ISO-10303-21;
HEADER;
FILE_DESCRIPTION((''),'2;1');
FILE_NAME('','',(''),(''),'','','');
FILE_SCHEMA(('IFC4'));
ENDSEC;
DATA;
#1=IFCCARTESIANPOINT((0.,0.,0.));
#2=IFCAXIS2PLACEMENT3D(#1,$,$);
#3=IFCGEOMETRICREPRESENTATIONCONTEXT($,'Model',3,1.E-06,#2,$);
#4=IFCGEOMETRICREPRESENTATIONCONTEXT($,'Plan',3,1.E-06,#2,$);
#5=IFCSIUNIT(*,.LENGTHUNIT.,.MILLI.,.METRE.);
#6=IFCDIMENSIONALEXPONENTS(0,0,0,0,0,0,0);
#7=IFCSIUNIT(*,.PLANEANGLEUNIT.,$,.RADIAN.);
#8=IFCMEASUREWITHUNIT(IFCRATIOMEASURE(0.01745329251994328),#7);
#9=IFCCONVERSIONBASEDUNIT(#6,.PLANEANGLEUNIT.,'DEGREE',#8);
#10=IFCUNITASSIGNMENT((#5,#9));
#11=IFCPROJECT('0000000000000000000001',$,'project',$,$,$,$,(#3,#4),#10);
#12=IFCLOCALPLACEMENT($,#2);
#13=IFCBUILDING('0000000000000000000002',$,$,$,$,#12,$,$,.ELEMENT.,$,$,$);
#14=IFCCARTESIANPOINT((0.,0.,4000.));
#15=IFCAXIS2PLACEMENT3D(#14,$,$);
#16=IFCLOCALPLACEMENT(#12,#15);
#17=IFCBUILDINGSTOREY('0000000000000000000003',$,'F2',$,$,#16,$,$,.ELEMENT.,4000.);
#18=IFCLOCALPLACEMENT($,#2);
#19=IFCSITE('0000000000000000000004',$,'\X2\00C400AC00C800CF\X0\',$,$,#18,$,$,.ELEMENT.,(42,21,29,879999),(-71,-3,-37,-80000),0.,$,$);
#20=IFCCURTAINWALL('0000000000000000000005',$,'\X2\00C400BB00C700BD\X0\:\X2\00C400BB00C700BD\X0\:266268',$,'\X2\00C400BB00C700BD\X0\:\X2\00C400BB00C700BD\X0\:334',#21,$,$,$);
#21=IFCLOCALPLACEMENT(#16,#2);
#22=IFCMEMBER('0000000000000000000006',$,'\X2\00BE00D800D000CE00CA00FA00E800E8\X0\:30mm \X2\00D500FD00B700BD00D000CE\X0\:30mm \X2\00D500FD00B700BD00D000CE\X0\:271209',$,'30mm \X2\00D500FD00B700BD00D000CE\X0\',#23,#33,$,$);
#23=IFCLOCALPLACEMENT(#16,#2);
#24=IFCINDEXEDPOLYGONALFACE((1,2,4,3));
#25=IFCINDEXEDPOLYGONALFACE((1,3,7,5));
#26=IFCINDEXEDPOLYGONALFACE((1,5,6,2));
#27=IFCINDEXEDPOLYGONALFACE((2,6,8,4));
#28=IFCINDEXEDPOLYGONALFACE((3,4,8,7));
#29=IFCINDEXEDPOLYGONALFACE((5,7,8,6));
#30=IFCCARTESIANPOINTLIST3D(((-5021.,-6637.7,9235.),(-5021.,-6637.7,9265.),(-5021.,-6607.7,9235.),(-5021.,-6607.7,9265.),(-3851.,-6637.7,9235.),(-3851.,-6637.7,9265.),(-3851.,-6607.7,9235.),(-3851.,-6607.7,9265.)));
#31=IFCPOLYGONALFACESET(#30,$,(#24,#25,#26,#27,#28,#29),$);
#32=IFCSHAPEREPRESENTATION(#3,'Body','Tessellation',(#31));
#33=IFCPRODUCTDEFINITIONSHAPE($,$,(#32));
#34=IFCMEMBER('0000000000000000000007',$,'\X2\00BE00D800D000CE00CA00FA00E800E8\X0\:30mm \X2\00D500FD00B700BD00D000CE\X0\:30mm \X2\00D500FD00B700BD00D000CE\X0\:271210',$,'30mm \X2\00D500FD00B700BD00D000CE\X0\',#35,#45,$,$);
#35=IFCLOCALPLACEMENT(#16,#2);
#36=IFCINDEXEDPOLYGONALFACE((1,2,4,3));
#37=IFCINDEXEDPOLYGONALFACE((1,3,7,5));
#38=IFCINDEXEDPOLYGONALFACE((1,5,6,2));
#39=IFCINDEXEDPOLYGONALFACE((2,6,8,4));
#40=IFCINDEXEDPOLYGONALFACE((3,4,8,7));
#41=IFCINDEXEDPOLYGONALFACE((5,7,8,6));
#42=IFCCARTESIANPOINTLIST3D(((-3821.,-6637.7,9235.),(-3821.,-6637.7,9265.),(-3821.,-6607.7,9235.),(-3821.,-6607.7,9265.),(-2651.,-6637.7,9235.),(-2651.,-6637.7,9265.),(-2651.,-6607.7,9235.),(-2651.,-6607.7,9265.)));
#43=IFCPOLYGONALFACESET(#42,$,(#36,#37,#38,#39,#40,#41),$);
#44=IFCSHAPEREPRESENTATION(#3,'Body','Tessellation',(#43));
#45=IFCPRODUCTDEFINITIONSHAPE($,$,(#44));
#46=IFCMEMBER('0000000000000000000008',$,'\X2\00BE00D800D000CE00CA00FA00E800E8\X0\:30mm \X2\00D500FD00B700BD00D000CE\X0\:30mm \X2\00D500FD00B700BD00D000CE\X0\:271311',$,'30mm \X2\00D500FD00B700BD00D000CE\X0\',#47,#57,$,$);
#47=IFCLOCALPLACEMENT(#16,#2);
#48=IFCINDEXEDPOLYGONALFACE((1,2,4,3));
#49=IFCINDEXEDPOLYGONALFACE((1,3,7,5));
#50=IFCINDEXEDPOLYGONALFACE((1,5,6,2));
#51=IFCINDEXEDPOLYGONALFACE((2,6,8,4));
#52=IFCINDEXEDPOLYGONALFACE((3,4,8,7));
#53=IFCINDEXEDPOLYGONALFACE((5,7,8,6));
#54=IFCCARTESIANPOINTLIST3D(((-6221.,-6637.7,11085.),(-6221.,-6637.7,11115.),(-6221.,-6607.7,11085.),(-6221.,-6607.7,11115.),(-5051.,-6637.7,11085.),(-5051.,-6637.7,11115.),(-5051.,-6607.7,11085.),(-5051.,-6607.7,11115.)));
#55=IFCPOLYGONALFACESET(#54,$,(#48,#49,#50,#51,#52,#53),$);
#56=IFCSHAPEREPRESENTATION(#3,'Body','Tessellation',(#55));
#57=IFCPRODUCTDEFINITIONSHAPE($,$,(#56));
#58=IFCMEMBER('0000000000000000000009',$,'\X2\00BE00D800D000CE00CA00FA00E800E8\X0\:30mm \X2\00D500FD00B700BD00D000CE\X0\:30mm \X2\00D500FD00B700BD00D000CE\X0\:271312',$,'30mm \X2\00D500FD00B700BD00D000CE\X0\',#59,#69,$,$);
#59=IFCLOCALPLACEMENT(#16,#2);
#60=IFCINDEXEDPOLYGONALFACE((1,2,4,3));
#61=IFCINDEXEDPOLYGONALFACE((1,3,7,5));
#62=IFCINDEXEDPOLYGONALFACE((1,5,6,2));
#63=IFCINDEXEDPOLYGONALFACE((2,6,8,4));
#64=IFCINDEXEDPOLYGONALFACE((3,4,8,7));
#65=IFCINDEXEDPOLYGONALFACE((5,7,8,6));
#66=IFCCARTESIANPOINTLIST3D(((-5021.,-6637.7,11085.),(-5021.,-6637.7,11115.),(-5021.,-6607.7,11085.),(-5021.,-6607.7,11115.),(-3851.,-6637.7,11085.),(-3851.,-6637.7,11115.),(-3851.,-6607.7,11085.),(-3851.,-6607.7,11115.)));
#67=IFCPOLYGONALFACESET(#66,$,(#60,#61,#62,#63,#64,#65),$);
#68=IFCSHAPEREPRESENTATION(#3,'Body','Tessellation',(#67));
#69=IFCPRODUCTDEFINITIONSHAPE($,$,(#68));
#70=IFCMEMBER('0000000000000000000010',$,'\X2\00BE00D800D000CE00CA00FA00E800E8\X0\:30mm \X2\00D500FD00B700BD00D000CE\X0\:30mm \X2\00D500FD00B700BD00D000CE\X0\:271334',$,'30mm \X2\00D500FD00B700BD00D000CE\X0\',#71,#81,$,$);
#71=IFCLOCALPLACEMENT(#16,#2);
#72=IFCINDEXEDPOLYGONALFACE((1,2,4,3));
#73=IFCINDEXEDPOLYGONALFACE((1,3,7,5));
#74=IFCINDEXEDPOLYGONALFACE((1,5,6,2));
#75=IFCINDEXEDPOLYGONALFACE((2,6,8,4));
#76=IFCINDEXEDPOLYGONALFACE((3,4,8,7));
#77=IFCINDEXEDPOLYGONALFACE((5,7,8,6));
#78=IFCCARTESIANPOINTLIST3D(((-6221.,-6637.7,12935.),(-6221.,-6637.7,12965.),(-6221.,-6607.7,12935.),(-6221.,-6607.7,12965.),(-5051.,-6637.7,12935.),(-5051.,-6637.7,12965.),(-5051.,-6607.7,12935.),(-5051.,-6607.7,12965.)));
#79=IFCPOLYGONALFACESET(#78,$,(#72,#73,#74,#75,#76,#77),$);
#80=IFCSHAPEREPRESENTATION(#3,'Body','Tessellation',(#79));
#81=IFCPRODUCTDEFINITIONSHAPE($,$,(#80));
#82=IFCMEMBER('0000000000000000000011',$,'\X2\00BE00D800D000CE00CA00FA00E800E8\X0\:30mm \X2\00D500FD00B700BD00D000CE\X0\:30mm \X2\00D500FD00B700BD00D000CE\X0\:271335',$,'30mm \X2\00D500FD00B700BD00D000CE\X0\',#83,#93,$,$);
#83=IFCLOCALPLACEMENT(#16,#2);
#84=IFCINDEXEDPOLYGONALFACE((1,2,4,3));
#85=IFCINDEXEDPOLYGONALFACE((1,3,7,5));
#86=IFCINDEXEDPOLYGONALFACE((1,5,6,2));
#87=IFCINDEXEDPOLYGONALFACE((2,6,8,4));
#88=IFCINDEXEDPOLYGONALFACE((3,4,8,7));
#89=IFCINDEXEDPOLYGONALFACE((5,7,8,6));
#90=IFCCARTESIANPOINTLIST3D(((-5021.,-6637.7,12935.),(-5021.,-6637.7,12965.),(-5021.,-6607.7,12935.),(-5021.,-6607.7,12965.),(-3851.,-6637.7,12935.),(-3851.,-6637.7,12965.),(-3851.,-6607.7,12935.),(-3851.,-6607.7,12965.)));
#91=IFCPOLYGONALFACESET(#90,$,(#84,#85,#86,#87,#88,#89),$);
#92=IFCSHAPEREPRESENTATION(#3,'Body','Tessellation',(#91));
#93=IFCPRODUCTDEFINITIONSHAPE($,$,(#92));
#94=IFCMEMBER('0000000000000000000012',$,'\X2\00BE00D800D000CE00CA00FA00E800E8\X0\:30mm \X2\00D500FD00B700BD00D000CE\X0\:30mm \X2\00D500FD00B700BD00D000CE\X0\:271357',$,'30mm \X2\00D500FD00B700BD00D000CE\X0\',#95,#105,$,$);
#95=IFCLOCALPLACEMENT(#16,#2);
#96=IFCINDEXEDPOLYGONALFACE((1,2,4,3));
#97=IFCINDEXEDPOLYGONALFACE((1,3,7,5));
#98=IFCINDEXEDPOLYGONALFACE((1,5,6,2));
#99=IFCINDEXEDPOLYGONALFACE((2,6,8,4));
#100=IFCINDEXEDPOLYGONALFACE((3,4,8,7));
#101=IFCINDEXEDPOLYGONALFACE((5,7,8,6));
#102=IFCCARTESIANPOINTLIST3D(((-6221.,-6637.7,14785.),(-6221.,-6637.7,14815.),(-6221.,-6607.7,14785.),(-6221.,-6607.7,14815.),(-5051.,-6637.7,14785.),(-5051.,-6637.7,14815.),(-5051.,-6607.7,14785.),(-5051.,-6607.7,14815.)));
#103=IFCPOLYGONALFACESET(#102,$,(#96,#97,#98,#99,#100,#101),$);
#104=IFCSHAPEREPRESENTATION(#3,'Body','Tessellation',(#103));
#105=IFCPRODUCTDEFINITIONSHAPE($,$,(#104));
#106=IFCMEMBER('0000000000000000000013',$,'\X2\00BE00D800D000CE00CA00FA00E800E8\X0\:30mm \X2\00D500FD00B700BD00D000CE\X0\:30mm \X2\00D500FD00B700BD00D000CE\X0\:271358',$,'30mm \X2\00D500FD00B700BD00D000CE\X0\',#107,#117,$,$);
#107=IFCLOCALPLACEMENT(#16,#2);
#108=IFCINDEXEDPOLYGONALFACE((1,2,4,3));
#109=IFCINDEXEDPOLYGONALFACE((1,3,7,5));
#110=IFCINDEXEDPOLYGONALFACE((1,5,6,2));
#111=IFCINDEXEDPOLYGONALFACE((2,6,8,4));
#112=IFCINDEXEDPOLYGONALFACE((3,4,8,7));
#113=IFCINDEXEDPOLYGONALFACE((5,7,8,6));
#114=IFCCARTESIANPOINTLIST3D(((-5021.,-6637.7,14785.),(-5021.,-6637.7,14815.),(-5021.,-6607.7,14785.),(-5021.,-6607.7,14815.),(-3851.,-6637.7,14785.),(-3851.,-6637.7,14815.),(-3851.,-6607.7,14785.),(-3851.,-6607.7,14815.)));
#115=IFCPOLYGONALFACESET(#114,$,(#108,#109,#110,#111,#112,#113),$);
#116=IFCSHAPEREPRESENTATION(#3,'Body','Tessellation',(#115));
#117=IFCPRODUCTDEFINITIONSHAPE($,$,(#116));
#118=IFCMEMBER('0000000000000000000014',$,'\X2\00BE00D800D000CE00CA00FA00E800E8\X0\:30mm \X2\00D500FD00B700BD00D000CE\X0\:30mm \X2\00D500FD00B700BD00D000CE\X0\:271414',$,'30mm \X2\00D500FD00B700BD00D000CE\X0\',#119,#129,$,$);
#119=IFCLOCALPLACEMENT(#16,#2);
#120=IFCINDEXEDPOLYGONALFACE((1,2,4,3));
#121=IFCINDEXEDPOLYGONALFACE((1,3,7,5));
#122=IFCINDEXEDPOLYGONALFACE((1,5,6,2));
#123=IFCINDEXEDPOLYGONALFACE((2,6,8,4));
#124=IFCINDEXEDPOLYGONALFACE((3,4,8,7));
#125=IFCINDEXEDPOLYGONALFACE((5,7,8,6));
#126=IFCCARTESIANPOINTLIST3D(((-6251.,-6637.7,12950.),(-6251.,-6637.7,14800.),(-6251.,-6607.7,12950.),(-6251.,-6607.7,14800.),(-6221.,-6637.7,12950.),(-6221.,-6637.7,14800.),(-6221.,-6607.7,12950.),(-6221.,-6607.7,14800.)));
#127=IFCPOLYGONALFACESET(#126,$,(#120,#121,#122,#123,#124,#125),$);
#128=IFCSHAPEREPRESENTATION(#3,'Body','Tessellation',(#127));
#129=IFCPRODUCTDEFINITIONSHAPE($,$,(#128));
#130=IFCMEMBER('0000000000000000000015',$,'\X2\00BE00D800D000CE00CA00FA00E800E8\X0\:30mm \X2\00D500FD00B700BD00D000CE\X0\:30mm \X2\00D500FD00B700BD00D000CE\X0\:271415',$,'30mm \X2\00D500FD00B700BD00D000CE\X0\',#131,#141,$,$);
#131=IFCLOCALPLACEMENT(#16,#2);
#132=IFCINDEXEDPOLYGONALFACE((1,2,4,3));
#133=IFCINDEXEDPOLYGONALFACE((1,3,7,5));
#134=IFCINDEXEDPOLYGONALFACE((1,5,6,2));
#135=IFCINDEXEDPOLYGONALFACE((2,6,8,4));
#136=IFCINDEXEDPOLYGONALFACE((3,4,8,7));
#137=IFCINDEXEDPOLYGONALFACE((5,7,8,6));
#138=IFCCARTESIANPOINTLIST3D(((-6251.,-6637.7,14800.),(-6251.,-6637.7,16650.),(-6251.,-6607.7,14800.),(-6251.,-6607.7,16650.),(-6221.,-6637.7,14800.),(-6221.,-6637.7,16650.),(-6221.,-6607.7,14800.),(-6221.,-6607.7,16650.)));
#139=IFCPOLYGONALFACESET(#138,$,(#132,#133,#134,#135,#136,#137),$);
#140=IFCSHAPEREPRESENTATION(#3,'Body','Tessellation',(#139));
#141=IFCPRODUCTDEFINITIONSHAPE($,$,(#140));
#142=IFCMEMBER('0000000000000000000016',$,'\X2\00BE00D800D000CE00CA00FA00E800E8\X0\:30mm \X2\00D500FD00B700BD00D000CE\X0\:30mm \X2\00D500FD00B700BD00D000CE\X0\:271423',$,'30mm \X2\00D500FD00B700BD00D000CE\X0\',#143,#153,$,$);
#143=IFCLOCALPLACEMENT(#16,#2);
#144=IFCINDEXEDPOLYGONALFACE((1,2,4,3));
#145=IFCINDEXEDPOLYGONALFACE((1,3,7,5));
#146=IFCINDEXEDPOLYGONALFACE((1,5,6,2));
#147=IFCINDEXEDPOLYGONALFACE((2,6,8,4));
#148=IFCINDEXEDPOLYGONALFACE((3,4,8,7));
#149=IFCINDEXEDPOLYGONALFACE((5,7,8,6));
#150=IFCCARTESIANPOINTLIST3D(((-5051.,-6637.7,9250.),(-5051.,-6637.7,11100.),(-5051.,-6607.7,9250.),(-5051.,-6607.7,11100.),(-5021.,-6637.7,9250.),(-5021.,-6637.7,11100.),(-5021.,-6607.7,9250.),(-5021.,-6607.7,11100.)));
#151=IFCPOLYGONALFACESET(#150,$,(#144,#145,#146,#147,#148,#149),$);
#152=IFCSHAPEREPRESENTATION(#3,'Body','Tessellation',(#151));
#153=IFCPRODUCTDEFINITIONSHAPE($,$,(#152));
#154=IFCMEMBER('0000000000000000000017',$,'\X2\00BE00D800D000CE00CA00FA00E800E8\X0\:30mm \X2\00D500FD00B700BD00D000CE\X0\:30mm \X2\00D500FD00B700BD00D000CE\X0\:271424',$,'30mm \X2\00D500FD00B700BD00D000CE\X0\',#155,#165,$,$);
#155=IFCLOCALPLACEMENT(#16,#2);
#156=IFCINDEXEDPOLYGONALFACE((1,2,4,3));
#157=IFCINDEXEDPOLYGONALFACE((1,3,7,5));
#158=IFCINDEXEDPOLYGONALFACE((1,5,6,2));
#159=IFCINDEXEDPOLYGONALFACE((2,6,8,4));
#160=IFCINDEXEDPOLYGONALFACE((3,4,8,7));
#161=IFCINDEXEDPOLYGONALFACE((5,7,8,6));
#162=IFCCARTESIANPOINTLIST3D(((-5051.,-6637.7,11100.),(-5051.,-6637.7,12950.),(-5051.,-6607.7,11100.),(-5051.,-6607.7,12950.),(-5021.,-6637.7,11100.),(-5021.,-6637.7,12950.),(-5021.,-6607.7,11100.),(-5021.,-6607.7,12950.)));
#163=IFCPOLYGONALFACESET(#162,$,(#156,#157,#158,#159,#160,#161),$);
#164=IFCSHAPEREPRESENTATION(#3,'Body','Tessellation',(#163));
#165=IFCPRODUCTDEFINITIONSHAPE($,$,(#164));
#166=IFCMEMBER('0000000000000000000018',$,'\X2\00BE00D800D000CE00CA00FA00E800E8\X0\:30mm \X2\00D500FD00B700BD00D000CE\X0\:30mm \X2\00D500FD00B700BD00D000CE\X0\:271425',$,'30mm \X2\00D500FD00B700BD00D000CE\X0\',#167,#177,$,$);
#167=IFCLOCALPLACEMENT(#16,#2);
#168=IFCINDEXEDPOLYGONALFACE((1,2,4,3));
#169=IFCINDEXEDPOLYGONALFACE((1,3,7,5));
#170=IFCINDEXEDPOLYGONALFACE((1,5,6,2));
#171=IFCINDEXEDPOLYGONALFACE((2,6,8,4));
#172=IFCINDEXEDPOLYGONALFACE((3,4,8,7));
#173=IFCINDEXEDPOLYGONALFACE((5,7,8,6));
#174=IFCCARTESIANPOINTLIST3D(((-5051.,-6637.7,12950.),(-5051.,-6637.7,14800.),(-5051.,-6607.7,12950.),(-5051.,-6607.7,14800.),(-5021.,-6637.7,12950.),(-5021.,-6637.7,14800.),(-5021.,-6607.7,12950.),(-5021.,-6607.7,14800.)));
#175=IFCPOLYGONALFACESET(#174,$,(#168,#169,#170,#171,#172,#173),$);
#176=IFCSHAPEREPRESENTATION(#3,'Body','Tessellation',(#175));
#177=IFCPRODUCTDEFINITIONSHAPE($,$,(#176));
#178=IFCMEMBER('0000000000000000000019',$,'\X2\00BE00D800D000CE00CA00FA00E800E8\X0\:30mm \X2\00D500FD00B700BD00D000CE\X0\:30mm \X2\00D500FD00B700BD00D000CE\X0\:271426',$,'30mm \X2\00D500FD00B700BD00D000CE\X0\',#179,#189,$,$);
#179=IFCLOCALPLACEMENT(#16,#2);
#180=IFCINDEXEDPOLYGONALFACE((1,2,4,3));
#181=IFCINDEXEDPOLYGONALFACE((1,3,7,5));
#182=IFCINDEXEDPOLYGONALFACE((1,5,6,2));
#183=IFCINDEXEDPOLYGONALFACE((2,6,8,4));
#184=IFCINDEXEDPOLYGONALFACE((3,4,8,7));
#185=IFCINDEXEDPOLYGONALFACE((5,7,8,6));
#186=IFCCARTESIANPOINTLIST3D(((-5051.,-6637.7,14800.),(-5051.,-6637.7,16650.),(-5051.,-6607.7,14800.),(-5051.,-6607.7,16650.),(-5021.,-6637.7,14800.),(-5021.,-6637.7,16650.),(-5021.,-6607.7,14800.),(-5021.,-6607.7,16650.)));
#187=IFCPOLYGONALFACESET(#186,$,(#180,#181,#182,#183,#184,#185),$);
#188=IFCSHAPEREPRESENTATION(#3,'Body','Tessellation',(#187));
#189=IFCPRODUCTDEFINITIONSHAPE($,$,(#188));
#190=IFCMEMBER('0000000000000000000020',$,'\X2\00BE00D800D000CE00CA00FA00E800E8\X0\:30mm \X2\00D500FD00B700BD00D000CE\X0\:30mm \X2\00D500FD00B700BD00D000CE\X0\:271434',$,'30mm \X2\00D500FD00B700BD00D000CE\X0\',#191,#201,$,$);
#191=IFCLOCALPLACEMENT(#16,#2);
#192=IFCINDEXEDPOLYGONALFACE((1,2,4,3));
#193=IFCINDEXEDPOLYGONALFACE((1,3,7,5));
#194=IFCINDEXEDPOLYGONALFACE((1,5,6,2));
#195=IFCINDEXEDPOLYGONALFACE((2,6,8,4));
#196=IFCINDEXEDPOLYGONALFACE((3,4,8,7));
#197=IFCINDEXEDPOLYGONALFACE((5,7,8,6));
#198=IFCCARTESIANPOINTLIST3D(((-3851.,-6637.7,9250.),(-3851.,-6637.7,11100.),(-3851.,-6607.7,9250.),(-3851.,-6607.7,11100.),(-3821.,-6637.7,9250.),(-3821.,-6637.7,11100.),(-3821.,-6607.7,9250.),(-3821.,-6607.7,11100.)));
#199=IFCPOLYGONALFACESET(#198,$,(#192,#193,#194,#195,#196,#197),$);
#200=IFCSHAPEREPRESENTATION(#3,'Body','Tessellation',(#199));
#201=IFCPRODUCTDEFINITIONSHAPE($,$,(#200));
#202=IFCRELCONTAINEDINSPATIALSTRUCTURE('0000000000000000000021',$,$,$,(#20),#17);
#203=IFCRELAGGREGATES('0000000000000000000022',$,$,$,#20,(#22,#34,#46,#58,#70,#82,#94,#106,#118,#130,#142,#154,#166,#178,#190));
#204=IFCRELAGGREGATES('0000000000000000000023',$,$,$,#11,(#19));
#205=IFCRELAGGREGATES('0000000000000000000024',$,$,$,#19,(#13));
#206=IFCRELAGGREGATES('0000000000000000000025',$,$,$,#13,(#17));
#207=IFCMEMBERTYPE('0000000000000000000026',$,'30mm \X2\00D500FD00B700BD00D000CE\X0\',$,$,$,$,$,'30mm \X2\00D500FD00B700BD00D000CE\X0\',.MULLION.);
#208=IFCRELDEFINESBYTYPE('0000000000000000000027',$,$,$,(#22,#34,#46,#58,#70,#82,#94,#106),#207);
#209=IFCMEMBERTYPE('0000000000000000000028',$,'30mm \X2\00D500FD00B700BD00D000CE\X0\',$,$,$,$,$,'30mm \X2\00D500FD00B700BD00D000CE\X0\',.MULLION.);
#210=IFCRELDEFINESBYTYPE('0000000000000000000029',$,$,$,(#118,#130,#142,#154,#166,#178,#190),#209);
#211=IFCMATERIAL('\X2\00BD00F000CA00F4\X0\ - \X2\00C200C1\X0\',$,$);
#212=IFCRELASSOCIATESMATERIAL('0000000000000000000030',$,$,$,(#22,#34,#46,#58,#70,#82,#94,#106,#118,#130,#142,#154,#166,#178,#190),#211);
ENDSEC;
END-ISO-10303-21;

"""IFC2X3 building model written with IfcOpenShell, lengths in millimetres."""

from ifc_helpers import new_model, entity, si_unit, converted_unit, frame, origin, origin_2d_with_axis, place, context, project, spatial, rectangle, extrude, source, transform, mapped, material, type_object, type_shapes, element, aggregate, save


model = new_model("IFC2X3")

# Units and contexts
model_context = context("Model", 3, precision=1e-06, world=origin())
plan_context = context("Plan", 3, precision=1e-06, world=origin())
ifc_project = project(units=[si_unit("LENGTHUNIT", "METRE", prefix="MILLI"), converted_unit("PLANEANGLEUNIT", "DEGREE", entity("IfcRatioMeasure", 0.01745329251994328), si_unit("PLANEANGLEUNIT", "RADIAN"), dimensions=[0, 0, 0, 0, 0, 0, 0])], contexts=[model_context, plan_context])

# Site, building, storey
site_placement = place(None, origin())
site = spatial("IfcSite", under=ifc_project, at=site_placement, Name="Ä¬ÈÏ", CompositionType="ELEMENT", RefLatitude=(42, 21, 29, 879999), RefLongitude=(-71, -3, -37, -80000), RefElevation=0.0)
building_placement = place(None, origin())
building = spatial("IfcBuilding", under=site, at=building_placement, CompositionType="ELEMENT")
storey_placement = place(building_placement, frame((0.0, 0.0, 4000.0)))
storey = spatial("IfcBuildingStorey", under=building, at=storey_placement, Name="F2", CompositionType="ELEMENT", Elevation=4000.0)

# Curtain wall, members
curtain_wall_placement = place(storey_placement, origin())
curtain_wall = element("IfcCurtainWall", 1, at=curtain_wall_placement, inside=storey, Name="Ä»Ç½:Ä»Ç½:266268", ObjectType="Ä»Ç½:Ä»Ç½:334")
ifc_material_1 = material(Name="½ðÊô - ÂÁ")
member_type_1 = type_object("IfcMemberType", Name="30mm Õý·½ÐÎ", ElementType="30mm Õý·½ÐÎ", PredefinedType="MULLION")
shared_shape_1 = source(origin(), model_context, "Body", "SweptSolid", [
    extrude(rectangle(XDim=30.0, YDim=30.0, at=origin_2d_with_axis()), frame((0.0, 0.0, -1170.0), z_axis=(0.0, 0.0, 1.0), x_axis=(-1.0, 0.0, 0.0)), (0.0, 0.0, 1.0), 1170.0),
])
type_shapes(member_type_1, [shared_shape_1])
placement_1 = place(building_placement, frame((0.0, 0.0, 11400.0)))
member_1_placement = place(placement_1, frame((-3851.0, -6622.7, 1850.0), z_axis=(1.0, 0.0, 0.0), x_axis=(0.0, 0.0, 1.0)))
member_1 = element("IfcMember", 2, at=member_1_placement, type_object=member_type_1, material=ifc_material_1, Name="¾ØÐÎÊúèè:30mm Õý·½ÐÎ:30mm Õý·½ÐÎ:271209", ObjectType="30mm Õý·½ÐÎ", context=model_context, shape_type="MappedRepresentation", body=[
    mapped(shared_shape_1, transform((0.0, 0.0, 0.0), scale=1.0)),
])
member_2_placement = place(placement_1, frame((-2651.0, -6622.7, 1850.0), z_axis=(1.0, 0.0, 0.0), x_axis=(0.0, 0.0, 1.0)))
member_2 = element("IfcMember", 3, at=member_2_placement, type_object=member_type_1, material=ifc_material_1, Name="¾ØÐÎÊúèè:30mm Õý·½ÐÎ:30mm Õý·½ÐÎ:271210", ObjectType="30mm Õý·½ÐÎ", context=model_context, shape_type="MappedRepresentation", body=[
    mapped(shared_shape_1, transform((0.0, 0.0, 0.0), scale=1.0)),
])
placement_2 = place(building_placement, frame((0.0, 0.0, 15100.0)))
member_3_placement = place(placement_2, frame((-5051.0, -6622.7, 0.0), z_axis=(1.0, 0.0, 0.0), x_axis=(0.0, 0.0, 1.0)))
member_3 = element("IfcMember", 4, at=member_3_placement, type_object=member_type_1, material=ifc_material_1, Name="¾ØÐÎÊúèè:30mm Õý·½ÐÎ:30mm Õý·½ÐÎ:271311", ObjectType="30mm Õý·½ÐÎ", context=model_context, shape_type="MappedRepresentation", body=[
    mapped(shared_shape_1, transform((0.0, 0.0, 0.0), scale=1.0)),
])
member_4_placement = place(placement_2, frame((-3851.0, -6622.7, 0.0), z_axis=(1.0, 0.0, 0.0), x_axis=(0.0, 0.0, 1.0)))
member_4 = element("IfcMember", 5, at=member_4_placement, type_object=member_type_1, material=ifc_material_1, Name="¾ØÐÎÊúèè:30mm Õý·½ÐÎ:30mm Õý·½ÐÎ:271312", ObjectType="30mm Õý·½ÐÎ", context=model_context, shape_type="MappedRepresentation", body=[
    mapped(shared_shape_1, transform((0.0, 0.0, 0.0), scale=1.0)),
])
member_5_placement = place(placement_2, frame((-5051.0, -6622.7, 1850.0), z_axis=(1.0, 0.0, 0.0), x_axis=(0.0, 0.0, 1.0)))
member_5 = element("IfcMember", 6, at=member_5_placement, type_object=member_type_1, material=ifc_material_1, Name="¾ØÐÎÊúèè:30mm Õý·½ÐÎ:30mm Õý·½ÐÎ:271334", ObjectType="30mm Õý·½ÐÎ", context=model_context, shape_type="MappedRepresentation", body=[
    mapped(shared_shape_1, transform((0.0, 0.0, 0.0), scale=1.0)),
])
member_6_placement = place(placement_2, frame((-3851.0, -6622.7, 1850.0), z_axis=(1.0, 0.0, 0.0), x_axis=(0.0, 0.0, 1.0)))
member_6 = element("IfcMember", 7, at=member_6_placement, type_object=member_type_1, material=ifc_material_1, Name="¾ØÐÎÊúèè:30mm Õý·½ÐÎ:30mm Õý·½ÐÎ:271335", ObjectType="30mm Õý·½ÐÎ", context=model_context, shape_type="MappedRepresentation", body=[
    mapped(shared_shape_1, transform((0.0, 0.0, 0.0), scale=1.0)),
])
placement_3 = place(building_placement, frame((0.0, 0.0, 18800.0)))
member_7_placement = place(placement_3, frame((-5051.0, -6622.7, 0.0), z_axis=(1.0, 0.0, 0.0), x_axis=(0.0, 0.0, 1.0)))
member_7 = element("IfcMember", 8, at=member_7_placement, type_object=member_type_1, material=ifc_material_1, Name="¾ØÐÎÊúèè:30mm Õý·½ÐÎ:30mm Õý·½ÐÎ:271357", ObjectType="30mm Õý·½ÐÎ", context=model_context, shape_type="MappedRepresentation", body=[
    mapped(shared_shape_1, transform((0.0, 0.0, 0.0), scale=1.0)),
])
member_8_placement = place(placement_3, frame((-3851.0, -6622.7, 0.0), z_axis=(1.0, 0.0, 0.0), x_axis=(0.0, 0.0, 1.0)))
member_8 = element("IfcMember", 9, at=member_8_placement, type_object=member_type_1, material=ifc_material_1, Name="¾ØÐÎÊúèè:30mm Õý·½ÐÎ:30mm Õý·½ÐÎ:271358", ObjectType="30mm Õý·½ÐÎ", context=model_context, shape_type="MappedRepresentation", body=[
    mapped(shared_shape_1, transform((0.0, 0.0, 0.0), scale=1.0)),
])
member_type_2 = type_object("IfcMemberType", Name="30mm Õý·½ÐÎ", ElementType="30mm Õý·½ÐÎ", PredefinedType="MULLION")
shared_shape_2 = source(origin(), model_context, "Body", "SweptSolid", [
    extrude(rectangle(XDim=30.0, YDim=30.0, at=origin_2d_with_axis()), frame((0.0, 0.0, -1850.0), z_axis=(0.0, 0.0, 1.0), x_axis=(-1.0, 0.0, 0.0)), (0.0, 0.0, 1.0), 1850.0),
])
type_shapes(member_type_2, [shared_shape_2])
member_9_placement = place(placement_2, frame((-6236.0, -6622.7, 1850.0), z_axis=(0.0, 0.0, -1.0), x_axis=(1.0, 0.0, 0.0)))
member_9 = element("IfcMember", 10, at=member_9_placement, type_object=member_type_2, material=ifc_material_1, Name="¾ØÐÎÊúèè:30mm Õý·½ÐÎ:30mm Õý·½ÐÎ:271414", ObjectType="30mm Õý·½ÐÎ", context=model_context, shape_type="MappedRepresentation", body=[
    mapped(shared_shape_2, transform((0.0, 0.0, 0.0), scale=1.0)),
])
member_10_placement = place(placement_3, frame((-6236.0, -6622.7, 0.0), z_axis=(0.0, 0.0, -1.0), x_axis=(1.0, 0.0, 0.0)))
member_10 = element("IfcMember", 11, at=member_10_placement, type_object=member_type_2, material=ifc_material_1, Name="¾ØÐÎÊúèè:30mm Õý·½ÐÎ:30mm Õý·½ÐÎ:271415", ObjectType="30mm Õý·½ÐÎ", context=model_context, shape_type="MappedRepresentation", body=[
    mapped(shared_shape_2, transform((0.0, 0.0, 0.0), scale=1.0)),
])
member_11_placement = place(placement_1, frame((-5036.0, -6622.7, 1850.0), z_axis=(0.0, 0.0, -1.0), x_axis=(1.0, 0.0, 0.0)))
member_11 = element("IfcMember", 12, at=member_11_placement, type_object=member_type_2, material=ifc_material_1, Name="¾ØÐÎÊúèè:30mm Õý·½ÐÎ:30mm Õý·½ÐÎ:271423", ObjectType="30mm Õý·½ÐÎ", context=model_context, shape_type="MappedRepresentation", body=[
    mapped(shared_shape_2, transform((0.0, 0.0, 0.0), scale=1.0)),
])
member_12_placement = place(placement_2, frame((-5036.0, -6622.7, 0.0), z_axis=(0.0, 0.0, -1.0), x_axis=(1.0, 0.0, 0.0)))
member_12 = element("IfcMember", 13, at=member_12_placement, type_object=member_type_2, material=ifc_material_1, Name="¾ØÐÎÊúèè:30mm Õý·½ÐÎ:30mm Õý·½ÐÎ:271424", ObjectType="30mm Õý·½ÐÎ", context=model_context, shape_type="MappedRepresentation", body=[
    mapped(shared_shape_2, transform((0.0, 0.0, 0.0), scale=1.0)),
])
member_13_placement = place(placement_2, frame((-5036.0, -6622.7, 1850.0), z_axis=(0.0, 0.0, -1.0), x_axis=(1.0, 0.0, 0.0)))
member_13 = element("IfcMember", 14, at=member_13_placement, type_object=member_type_2, material=ifc_material_1, Name="¾ØÐÎÊúèè:30mm Õý·½ÐÎ:30mm Õý·½ÐÎ:271425", ObjectType="30mm Õý·½ÐÎ", context=model_context, shape_type="MappedRepresentation", body=[
    mapped(shared_shape_2, transform((0.0, 0.0, 0.0), scale=1.0)),
])
member_14_placement = place(placement_3, frame((-5036.0, -6622.7, 0.0), z_axis=(0.0, 0.0, -1.0), x_axis=(1.0, 0.0, 0.0)))
member_14 = element("IfcMember", 15, at=member_14_placement, type_object=member_type_2, material=ifc_material_1, Name="¾ØÐÎÊúèè:30mm Õý·½ÐÎ:30mm Õý·½ÐÎ:271426", ObjectType="30mm Õý·½ÐÎ", context=model_context, shape_type="MappedRepresentation", body=[
    mapped(shared_shape_2, transform((0.0, 0.0, 0.0), scale=1.0)),
])
member_15_placement = place(placement_1, frame((-3836.0, -6622.7, 1850.0), z_axis=(0.0, 0.0, -1.0), x_axis=(1.0, 0.0, 0.0)))
member_15 = element("IfcMember", 16, at=member_15_placement, type_object=member_type_2, material=ifc_material_1, Name="¾ØÐÎÊúèè:30mm Õý·½ÐÎ:30mm Õý·½ÐÎ:271434", ObjectType="30mm Õý·½ÐÎ", context=model_context, shape_type="MappedRepresentation", body=[
    mapped(shared_shape_2, transform((0.0, 0.0, 0.0), scale=1.0)),
])
aggregate(curtain_wall, [member_1, member_2, member_3, member_4, member_5, member_6, member_7, member_8, member_9, member_10, member_11, member_12, member_13, member_14, member_15])

save(model, "model.ifc")
